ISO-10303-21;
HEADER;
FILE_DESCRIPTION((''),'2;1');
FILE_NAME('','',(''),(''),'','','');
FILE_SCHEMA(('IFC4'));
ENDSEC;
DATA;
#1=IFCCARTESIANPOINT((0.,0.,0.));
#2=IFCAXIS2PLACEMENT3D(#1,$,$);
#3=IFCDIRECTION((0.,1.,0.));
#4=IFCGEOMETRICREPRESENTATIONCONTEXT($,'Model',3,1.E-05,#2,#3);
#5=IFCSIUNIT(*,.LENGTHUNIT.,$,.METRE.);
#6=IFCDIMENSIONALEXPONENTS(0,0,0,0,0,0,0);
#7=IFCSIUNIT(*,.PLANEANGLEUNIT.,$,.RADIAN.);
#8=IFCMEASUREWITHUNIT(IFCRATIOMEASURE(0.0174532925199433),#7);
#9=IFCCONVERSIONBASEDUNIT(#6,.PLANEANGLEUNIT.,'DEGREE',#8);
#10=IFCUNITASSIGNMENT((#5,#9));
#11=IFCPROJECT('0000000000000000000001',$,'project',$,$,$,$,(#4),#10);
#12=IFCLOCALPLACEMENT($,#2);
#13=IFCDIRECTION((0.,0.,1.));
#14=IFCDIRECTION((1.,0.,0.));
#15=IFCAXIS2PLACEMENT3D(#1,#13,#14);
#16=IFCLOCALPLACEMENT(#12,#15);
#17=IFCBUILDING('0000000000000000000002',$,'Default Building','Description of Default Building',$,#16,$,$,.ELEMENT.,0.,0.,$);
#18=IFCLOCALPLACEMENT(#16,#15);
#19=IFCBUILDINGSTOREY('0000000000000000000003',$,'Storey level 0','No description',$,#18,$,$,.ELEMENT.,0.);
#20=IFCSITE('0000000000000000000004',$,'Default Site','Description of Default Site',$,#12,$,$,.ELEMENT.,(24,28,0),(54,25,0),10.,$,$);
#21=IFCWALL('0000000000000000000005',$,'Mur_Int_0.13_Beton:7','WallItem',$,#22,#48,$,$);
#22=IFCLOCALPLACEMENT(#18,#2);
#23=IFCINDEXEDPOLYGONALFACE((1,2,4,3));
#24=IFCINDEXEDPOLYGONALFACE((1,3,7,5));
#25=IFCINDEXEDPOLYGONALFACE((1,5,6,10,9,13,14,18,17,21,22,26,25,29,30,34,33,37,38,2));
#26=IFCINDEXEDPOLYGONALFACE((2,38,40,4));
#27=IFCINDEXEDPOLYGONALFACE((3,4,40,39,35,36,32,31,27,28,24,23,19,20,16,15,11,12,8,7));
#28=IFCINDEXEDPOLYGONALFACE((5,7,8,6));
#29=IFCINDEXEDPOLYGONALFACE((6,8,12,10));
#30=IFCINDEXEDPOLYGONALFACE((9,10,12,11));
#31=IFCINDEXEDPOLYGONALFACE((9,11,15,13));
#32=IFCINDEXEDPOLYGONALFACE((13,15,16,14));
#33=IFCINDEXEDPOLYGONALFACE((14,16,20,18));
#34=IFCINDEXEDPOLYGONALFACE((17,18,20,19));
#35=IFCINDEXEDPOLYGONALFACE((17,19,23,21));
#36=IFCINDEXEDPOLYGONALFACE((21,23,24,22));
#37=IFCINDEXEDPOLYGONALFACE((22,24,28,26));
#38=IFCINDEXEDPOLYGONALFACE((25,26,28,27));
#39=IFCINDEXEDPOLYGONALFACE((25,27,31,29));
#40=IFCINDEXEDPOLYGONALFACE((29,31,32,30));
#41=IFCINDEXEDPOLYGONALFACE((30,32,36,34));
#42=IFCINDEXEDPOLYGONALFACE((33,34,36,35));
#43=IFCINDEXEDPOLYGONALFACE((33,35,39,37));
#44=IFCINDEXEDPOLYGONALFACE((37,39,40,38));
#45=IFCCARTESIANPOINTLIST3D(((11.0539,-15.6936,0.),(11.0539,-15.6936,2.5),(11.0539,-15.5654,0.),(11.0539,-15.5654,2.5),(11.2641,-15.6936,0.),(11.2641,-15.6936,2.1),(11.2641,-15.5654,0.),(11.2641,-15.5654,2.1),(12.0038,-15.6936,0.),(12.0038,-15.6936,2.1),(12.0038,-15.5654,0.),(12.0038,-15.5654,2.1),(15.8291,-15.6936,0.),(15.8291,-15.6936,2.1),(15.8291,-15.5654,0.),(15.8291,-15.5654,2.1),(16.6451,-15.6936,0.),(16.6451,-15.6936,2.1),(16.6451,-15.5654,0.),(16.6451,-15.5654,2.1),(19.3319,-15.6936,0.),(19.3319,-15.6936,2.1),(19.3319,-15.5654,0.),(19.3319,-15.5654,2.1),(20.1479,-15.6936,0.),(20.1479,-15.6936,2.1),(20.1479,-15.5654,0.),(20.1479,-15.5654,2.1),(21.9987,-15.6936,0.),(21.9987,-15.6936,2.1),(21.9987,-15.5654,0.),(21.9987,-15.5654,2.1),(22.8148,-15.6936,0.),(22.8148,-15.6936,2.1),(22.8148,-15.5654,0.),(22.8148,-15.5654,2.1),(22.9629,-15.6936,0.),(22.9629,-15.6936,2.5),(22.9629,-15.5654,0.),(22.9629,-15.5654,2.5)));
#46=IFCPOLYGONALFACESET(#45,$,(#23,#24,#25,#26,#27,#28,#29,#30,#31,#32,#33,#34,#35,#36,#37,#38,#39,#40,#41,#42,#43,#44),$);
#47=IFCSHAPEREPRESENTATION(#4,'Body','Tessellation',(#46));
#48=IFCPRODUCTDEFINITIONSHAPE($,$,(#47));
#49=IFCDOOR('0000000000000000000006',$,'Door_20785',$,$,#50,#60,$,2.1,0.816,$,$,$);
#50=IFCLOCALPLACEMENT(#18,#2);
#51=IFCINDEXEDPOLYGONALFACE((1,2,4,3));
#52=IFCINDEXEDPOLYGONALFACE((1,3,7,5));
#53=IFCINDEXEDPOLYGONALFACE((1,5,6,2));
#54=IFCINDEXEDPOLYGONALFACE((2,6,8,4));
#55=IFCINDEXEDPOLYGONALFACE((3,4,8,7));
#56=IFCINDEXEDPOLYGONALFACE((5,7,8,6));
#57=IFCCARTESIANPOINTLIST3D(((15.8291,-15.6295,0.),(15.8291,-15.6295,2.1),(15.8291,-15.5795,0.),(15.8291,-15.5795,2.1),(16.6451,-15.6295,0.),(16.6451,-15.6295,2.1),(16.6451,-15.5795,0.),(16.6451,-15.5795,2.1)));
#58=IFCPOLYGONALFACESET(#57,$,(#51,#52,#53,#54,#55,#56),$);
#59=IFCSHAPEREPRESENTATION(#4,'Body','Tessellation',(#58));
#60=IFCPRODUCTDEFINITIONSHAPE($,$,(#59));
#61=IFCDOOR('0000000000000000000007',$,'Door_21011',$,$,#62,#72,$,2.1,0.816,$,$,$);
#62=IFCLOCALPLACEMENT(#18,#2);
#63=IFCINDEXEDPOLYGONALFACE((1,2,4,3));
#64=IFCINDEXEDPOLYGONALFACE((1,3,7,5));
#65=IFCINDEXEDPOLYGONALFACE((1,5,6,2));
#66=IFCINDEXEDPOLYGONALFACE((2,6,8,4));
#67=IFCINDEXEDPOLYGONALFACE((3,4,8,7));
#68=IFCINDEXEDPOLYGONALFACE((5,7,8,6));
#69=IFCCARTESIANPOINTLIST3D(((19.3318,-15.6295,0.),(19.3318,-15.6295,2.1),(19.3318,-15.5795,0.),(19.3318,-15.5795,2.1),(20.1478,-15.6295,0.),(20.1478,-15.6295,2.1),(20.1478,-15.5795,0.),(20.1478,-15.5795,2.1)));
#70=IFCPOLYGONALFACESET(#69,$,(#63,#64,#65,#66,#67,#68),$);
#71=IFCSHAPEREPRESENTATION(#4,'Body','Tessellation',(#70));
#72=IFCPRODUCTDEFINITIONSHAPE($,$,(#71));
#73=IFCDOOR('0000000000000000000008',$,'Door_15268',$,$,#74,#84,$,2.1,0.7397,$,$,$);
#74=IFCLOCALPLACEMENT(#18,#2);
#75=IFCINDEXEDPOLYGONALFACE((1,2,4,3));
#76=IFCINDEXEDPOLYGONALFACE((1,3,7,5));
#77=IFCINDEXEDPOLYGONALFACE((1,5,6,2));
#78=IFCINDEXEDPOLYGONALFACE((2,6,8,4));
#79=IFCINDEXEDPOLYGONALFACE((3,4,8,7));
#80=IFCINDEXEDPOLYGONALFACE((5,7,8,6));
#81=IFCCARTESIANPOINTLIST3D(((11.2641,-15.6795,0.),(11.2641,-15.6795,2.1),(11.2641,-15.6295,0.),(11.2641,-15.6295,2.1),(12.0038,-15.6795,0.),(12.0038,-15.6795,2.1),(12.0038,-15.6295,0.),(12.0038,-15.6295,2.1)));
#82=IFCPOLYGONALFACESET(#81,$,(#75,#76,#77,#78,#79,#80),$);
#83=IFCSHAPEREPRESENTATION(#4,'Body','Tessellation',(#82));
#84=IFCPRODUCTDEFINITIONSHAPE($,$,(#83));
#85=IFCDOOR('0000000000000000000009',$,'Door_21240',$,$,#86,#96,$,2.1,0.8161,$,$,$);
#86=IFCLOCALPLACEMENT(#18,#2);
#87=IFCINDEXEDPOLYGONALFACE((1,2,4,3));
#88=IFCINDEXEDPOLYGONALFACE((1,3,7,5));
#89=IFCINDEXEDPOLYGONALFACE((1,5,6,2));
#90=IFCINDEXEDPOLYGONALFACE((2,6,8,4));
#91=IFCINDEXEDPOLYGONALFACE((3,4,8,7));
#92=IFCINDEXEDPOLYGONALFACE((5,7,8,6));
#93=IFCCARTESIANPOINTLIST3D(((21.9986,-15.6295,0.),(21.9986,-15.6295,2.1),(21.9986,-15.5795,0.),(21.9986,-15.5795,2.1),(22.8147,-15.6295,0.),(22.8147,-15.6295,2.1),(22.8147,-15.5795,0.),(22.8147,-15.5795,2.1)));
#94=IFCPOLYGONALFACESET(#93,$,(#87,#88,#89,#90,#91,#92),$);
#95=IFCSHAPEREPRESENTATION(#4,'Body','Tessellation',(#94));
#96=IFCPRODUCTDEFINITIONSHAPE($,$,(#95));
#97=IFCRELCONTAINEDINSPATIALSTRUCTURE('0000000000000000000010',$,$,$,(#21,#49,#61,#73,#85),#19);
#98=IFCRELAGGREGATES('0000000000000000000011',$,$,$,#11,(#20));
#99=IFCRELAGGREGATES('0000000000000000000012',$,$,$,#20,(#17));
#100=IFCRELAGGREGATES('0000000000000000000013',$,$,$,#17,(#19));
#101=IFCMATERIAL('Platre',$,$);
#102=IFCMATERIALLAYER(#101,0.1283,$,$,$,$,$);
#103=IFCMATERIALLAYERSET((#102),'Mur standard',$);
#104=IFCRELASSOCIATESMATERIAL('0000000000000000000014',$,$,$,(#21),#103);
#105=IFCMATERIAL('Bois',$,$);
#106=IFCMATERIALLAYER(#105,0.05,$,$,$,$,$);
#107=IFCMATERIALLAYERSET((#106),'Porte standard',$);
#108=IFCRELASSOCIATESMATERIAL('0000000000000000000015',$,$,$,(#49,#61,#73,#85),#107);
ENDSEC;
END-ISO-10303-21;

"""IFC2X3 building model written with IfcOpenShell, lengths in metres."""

from ifc_helpers import new_model, entity, si_unit, converted_unit, direction, frame, origin, origin_with_axes, place, context, project, spatial, polyline, outline, extrude, material, layer, layer_set, layer_usage, element, fill, save


model = new_model("IFC2X3")

# Units and contexts
model_context = context("Model", 3, precision=1e-05, world=origin(), true_north=direction((0.0, 1.0, 0.0)))
ifc_project = project(units=[si_unit("LENGTHUNIT", "METRE"), converted_unit("PLANEANGLEUNIT", "DEGREE", entity("IfcRatioMeasure", 0.0174532925199433), si_unit("PLANEANGLEUNIT", "RADIAN"), dimensions=[0, 0, 0, 0, 0, 0, 0])], contexts=[model_context])

# Site, building, storey
site_placement = place(None, origin())
site = spatial("IfcSite", under=ifc_project, at=site_placement, Name="Default Site", Description="Description of Default Site", CompositionType="ELEMENT", RefLatitude=(24, 28, 0), RefLongitude=(54, 25, 0), RefElevation=10.0)
building_placement = place(site_placement, origin_with_axes())
building = spatial("IfcBuilding", under=site, at=building_placement, Name="Default Building", Description="Description of Default Building", CompositionType="ELEMENT", ElevationOfRefHeight=0.0, ElevationOfTerrain=0.0)
storey_placement = place(building_placement, origin_with_axes())
storey = spatial("IfcBuildingStorey", under=building, at=storey_placement, Name="Storey level 0", Description="No description", CompositionType="ELEMENT", Elevation=0.0)

# Shared definitions
ifc_material_1 = material(Name="Bois")
ifc_layer_1 = layer(ifc_material_1, 0.05)
ifc_layer_set_1 = layer_set([ifc_layer_1], Name="Porte standard")
ifc_layer_usage_1 = layer_usage(ifc_layer_set_1, "AXIS2", "NEGATIVE", 0.05)

# Wall, openings, doors
ifc_material_2 = material(Name="Platre")
ifc_layer_2 = layer(ifc_material_2, 0.1283)
ifc_layer_set_2 = layer_set([ifc_layer_2], Name="Mur standard")
ifc_layer_usage_2 = layer_usage(ifc_layer_set_2, "AXIS2", "NEGATIVE", 0.1283)
wall_1_placement = place(storey_placement, frame((10.9684, -15.6295, 0.0), z_axis=(0.0, 0.0, 1.0), x_axis=(1.0, 0.0, 0.0)))
wall_1 = element("IfcWall", 1, at=wall_1_placement, inside=storey, material=ifc_layer_usage_2, Name="Mur_Int_0.13_Beton:7", Description="WallItem", context=model_context, shape_type="SweptSolid", body=[
    extrude(outline(polyline([(0.0855, 0.0641), (0.0855, -0.0641), (11.9945, -0.0641), (11.9945, 0.0641), (0.0855, 0.0641)])), origin(), (0.0, 0.0, 1.0), 2.5),
])
opening_1_placement = place(storey_placement, frame((16.6451, -15.6936, 0.0), z_axis=(0.0, 0.0, 1.0), x_axis=(-1.0, 0.0, 0.0)))
opening_1 = element("IfcOpeningElement", 2, at=opening_1_placement, cuts=wall_1, context=model_context, shape_type="SweptSolid", body=[
    extrude(outline(polyline([(0.816, 0.05), (0.0, 0.05), (0.0, -0.1783), (0.816, -0.1783), (0.816, 0.05)])), origin(), (0.0, 0.0, 1.0), 2.1),
])
opening_2_placement = place(storey_placement, frame((20.1479, -15.6936, 0.0), z_axis=(0.0, 0.0, 1.0), x_axis=(-1.0, 0.0, 0.0)))
opening_2 = element("IfcOpeningElement", 3, at=opening_2_placement, cuts=wall_1, context=model_context, shape_type="SweptSolid", body=[
    extrude(outline(polyline([(0.816, 0.05), (0.0, 0.05), (0.0, -0.1783), (0.816, -0.1783), (0.816, 0.05)])), origin(), (0.0, 0.0, 1.0), 2.1),
])
opening_3_placement = place(storey_placement, frame((11.2641, -15.6936, 0.0), z_axis=(0.0, 0.0, 1.0), x_axis=(1.0, 0.0, 0.0)))
opening_3 = element("IfcOpeningElement", 4, at=opening_3_placement, cuts=wall_1, context=model_context, shape_type="SweptSolid", body=[
    extrude(outline(polyline([(0.0, -0.05), (0.7397, -0.05), (0.7397, 0.1783), (0.0, 0.1783), (0.0, -0.05)])), origin(), (0.0, 0.0, 1.0), 2.1),
])
opening_4_placement = place(storey_placement, frame((22.8148, -15.6936, 0.0), z_axis=(0.0, 0.0, 1.0), x_axis=(-1.0, 0.0, 0.0)))
opening_4 = element("IfcOpeningElement", 5, at=opening_4_placement, cuts=wall_1, context=model_context, shape_type="SweptSolid", body=[
    extrude(outline(polyline([(0.8161, 0.05), (0.0, 0.05), (0.0, -0.1783), (0.8161, -0.1783), (0.8161, 0.05)])), origin(), (0.0, 0.0, 1.0), 2.1),
])
door_1_placement = place(wall_1_placement, frame((5.6767, 0.0, 0.0), z_axis=(0.0, 0.0, 1.0), x_axis=(-1.0, 0.0, 0.0)))
door_1 = element("IfcDoor", 6, at=door_1_placement, inside=storey, material=ifc_layer_usage_1, Name="Door_20785", OverallHeight=2.1, OverallWidth=0.816, context=model_context, shape_type="SweptSolid", body=[
    extrude(outline(polyline([(0.0, 0.0), (0.816, 0.0), (0.816, -0.05), (0.0, -0.05), (0.0, 0.0)])), origin(), (0.0, 0.0, 1.0), 2.1),
])
fill(opening_1, door_1)
door_2_placement = place(wall_1_placement, frame((9.1794, 0.0, 0.0), z_axis=(0.0, 0.0, 1.0), x_axis=(-1.0, 0.0, 0.0)))
door_2 = element("IfcDoor", 7, at=door_2_placement, inside=storey, material=ifc_layer_usage_1, Name="Door_21011", OverallHeight=2.1, OverallWidth=0.816, context=model_context, shape_type="SweptSolid", body=[
    extrude(outline(polyline([(0.0, 0.0), (0.816, 0.0), (0.816, -0.05), (0.0, -0.05), (0.0, 0.0)])), origin(), (0.0, 0.0, 1.0), 2.1),
])
fill(opening_2, door_2)
door_3_placement = place(wall_1_placement, frame((0.2957, 0.0, 0.0), z_axis=(0.0, 0.0, 1.0), x_axis=(1.0, 0.0, 0.0)))
door_3 = element("IfcDoor", 8, at=door_3_placement, inside=storey, material=ifc_layer_usage_1, Name="Door_15268", OverallHeight=2.1, OverallWidth=0.7397, context=model_context, shape_type="SweptSolid", body=[
    extrude(outline(polyline([(0.0, 0.0), (0.7397, 0.0), (0.7397, -0.05), (0.0, -0.05), (0.0, 0.0)])), origin(), (0.0, 0.0, 1.0), 2.1),
])
fill(opening_3, door_3)
door_4_placement = place(wall_1_placement, frame((11.8463, 0.0, 0.0), z_axis=(0.0, 0.0, 1.0), x_axis=(-1.0, 0.0, 0.0)))
door_4 = element("IfcDoor", 9, at=door_4_placement, inside=storey, material=ifc_layer_usage_1, Name="Door_21240", OverallHeight=2.1, OverallWidth=0.8161, context=model_context, shape_type="SweptSolid", body=[
    extrude(outline(polyline([(0.0, 0.0), (0.8161, 0.0), (0.8161, -0.05), (0.0, -0.05), (0.0, 0.0)])), origin(), (0.0, 0.0, 1.0), 2.1),
])
fill(opening_4, door_4)

save(model, "model.ifc")
